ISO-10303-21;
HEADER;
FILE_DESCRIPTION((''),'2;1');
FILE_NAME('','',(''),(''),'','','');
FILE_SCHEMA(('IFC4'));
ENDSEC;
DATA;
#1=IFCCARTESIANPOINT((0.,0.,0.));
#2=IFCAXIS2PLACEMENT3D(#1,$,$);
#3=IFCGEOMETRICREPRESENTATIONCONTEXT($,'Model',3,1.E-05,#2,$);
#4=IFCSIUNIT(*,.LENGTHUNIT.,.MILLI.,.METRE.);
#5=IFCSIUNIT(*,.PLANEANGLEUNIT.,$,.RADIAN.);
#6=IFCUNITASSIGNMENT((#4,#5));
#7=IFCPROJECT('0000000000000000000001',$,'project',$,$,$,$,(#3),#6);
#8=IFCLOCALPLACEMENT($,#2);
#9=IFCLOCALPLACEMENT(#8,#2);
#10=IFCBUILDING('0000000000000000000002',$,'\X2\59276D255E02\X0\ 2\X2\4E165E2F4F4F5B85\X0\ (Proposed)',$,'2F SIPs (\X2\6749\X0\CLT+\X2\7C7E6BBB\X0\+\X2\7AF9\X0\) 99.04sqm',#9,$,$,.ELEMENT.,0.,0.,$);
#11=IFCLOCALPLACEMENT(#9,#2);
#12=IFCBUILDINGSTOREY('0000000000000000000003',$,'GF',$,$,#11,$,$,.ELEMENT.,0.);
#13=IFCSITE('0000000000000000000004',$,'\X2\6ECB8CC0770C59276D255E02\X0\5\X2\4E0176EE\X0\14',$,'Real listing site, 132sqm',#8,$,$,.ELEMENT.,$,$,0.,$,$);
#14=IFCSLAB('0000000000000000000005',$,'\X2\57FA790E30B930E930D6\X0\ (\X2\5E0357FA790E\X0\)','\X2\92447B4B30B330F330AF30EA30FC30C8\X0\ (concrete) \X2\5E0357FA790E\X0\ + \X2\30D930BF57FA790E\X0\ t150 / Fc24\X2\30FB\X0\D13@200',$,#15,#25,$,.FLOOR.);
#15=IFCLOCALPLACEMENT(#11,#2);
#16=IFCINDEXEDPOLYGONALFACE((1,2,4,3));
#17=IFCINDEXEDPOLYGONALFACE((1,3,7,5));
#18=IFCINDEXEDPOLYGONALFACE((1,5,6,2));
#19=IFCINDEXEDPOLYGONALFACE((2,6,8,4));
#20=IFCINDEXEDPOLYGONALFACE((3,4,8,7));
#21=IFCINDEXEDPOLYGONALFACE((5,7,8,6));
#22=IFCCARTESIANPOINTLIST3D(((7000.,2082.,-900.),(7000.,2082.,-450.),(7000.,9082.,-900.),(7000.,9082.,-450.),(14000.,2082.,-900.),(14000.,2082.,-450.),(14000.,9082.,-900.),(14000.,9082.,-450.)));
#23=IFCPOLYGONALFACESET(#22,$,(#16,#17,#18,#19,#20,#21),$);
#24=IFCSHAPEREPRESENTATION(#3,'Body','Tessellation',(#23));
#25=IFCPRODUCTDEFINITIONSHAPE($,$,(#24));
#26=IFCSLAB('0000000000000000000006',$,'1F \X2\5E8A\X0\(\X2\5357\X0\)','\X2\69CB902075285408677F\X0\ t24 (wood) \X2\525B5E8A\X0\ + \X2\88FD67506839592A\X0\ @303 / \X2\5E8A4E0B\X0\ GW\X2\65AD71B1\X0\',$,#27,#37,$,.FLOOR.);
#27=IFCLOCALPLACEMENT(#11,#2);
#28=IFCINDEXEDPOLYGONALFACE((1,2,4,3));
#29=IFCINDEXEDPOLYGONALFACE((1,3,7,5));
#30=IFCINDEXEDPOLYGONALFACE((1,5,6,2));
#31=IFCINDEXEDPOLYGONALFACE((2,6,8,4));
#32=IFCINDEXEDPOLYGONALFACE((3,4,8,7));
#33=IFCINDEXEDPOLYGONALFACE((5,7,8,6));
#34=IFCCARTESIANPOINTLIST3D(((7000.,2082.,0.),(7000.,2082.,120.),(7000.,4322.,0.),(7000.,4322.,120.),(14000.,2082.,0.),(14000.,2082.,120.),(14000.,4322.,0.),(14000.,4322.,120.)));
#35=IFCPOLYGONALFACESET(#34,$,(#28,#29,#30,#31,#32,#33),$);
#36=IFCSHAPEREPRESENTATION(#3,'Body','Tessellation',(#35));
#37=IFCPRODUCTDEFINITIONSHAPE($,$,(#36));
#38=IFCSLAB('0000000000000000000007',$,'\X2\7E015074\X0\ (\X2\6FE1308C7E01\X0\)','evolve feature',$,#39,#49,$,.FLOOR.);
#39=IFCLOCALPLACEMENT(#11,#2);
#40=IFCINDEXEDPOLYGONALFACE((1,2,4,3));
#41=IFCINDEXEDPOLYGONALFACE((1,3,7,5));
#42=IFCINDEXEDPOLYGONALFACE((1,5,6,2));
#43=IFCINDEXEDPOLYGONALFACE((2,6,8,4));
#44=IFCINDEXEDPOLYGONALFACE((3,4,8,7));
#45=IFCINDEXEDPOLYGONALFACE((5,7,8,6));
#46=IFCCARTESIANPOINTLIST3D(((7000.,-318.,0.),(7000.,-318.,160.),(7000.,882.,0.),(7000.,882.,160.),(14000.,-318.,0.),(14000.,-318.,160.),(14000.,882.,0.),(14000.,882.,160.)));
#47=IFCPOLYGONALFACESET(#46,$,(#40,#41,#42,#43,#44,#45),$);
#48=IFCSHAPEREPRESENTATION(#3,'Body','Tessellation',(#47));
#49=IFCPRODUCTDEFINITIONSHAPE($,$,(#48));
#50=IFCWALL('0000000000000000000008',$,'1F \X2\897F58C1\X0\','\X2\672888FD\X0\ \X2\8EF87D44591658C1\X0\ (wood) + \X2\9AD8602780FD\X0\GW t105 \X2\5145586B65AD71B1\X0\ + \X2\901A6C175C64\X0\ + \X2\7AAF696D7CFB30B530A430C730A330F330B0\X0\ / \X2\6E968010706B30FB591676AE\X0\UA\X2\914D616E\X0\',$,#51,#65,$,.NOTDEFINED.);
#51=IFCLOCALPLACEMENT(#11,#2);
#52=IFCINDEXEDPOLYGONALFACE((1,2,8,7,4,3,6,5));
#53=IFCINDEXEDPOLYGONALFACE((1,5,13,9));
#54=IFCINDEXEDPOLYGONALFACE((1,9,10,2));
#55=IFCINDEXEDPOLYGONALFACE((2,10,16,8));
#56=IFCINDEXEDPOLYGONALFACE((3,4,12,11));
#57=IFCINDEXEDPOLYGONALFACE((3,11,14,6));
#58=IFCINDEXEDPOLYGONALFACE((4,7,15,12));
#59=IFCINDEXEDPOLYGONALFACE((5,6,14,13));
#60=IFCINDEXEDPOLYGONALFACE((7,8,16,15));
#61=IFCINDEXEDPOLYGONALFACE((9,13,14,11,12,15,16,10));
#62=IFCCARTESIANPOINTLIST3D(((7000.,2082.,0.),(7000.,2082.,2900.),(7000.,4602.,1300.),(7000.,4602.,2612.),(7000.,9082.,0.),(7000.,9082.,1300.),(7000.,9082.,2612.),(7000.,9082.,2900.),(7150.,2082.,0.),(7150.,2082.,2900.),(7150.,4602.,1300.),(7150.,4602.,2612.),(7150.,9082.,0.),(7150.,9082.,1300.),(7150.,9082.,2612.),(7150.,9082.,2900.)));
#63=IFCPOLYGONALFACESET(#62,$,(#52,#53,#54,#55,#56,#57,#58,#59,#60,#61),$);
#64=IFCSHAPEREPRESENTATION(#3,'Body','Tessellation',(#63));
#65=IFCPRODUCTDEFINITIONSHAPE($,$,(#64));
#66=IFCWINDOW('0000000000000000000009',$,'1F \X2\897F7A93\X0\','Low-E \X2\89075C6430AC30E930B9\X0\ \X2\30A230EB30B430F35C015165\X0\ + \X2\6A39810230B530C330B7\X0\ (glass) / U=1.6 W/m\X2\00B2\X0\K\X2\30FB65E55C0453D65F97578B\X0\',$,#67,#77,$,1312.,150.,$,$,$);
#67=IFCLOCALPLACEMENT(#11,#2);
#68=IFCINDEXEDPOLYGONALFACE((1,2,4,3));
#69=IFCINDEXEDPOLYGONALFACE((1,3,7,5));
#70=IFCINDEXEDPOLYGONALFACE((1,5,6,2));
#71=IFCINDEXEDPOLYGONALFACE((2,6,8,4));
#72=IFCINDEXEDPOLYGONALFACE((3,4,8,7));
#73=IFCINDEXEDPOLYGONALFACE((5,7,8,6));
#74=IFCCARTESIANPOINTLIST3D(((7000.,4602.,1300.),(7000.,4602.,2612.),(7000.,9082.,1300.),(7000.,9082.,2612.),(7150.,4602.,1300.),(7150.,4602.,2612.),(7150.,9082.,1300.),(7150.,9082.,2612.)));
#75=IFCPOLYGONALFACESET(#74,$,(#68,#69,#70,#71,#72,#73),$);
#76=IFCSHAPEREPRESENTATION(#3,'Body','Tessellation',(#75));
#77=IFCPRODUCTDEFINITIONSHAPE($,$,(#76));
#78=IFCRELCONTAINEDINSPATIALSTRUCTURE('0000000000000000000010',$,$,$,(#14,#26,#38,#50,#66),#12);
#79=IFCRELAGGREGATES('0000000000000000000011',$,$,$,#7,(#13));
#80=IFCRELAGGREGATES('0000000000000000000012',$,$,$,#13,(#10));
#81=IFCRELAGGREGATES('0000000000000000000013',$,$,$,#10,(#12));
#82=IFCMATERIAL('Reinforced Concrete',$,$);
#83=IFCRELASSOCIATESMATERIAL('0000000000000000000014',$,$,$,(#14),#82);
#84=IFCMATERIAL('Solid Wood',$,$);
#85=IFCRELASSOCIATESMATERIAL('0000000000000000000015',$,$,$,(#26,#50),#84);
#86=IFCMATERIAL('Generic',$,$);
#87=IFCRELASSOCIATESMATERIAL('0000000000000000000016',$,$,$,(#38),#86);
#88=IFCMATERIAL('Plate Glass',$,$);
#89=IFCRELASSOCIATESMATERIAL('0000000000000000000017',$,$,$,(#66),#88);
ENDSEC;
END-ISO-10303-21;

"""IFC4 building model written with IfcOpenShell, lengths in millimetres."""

from ifc_helpers import new_model, si_unit, frame, frame_2d, origin, place, context, project, spatial, rectangle, extrude, material, element, fill, save


model = new_model("IFC4")

# Units and contexts
model_context = context("Model", 3, precision=1e-05, world=origin())
ifc_project = project(units=[si_unit("LENGTHUNIT", "METRE", prefix="MILLI"), si_unit("PLANEANGLEUNIT", "RADIAN")], contexts=[model_context])

# Site, building, storey
site_placement = place(None, origin())
site = spatial("IfcSite", under=ifc_project, at=site_placement, Name="滋賀県大津市5丁目14", ObjectType="Real listing site, 132sqm", CompositionType="ELEMENT", RefElevation=0.0)
building_placement = place(site_placement, origin())
building = spatial("IfcBuilding", under=site, at=building_placement, Name="大津市 2世帯住宅 (Proposed)", ObjectType="2F SIPs (杉CLT+籾殻+竹) 99.04sqm", CompositionType="ELEMENT", ElevationOfRefHeight=0.0, ElevationOfTerrain=0.0)
storey_placement = place(building_placement, origin())
storey = spatial("IfcBuildingStorey", under=building, at=storey_placement, Name="GF", CompositionType="ELEMENT", Elevation=0.0)

# Slabs
ifc_material_1 = material(Name="Reinforced Concrete")
slab_1_placement = place(storey_placement, frame((3500.0, 1041.0, -450.0)))
element("IfcSlab", 1, at=slab_1_placement, inside=storey, material=ifc_material_1, Name="基礎スラブ (布基礎)", Description="鉄筋コンクリート (concrete) 布基礎 + ベタ基礎 t150 / Fc24・D13@200", PredefinedType="FLOOR", context=model_context, shape_type="SweptSolid", body=[
    extrude(rectangle(XDim=7000.0, YDim=7000.0, at=frame_2d((3500.0, 3500.0))), frame((3500.0, 1041.0, -450.0)), (0.0, 0.0, 1.0), 450.0),
])
ifc_material_2 = material(Name="Solid Wood")
slab_2_placement = place(storey_placement, frame((3500.0, 1041.0, 0.0)))
element("IfcSlab", 2, at=slab_2_placement, inside=storey, material=ifc_material_2, Name="1F 床(南)", Description="構造用合板 t24 (wood) 剛床 + 製材根太 @303 / 床下 GW断熱", PredefinedType="FLOOR", context=model_context, shape_type="SweptSolid", body=[
    extrude(rectangle(XDim=7000.0, YDim=2240.0, at=frame_2d((3500.0, 1120.0))), frame((3500.0, 1041.0, 0.0)), (0.0, 0.0, 1.0), 120.0),
])
ifc_material_3 = material(Name="Generic")
slab_3_placement = place(storey_placement, frame((3500.0, -159.0, 0.0)))
element("IfcSlab", 3, at=slab_3_placement, inside=storey, material=ifc_material_3, Name="縁側 (濡れ縁)", Description="evolve feature", PredefinedType="FLOOR", context=model_context, shape_type="SweptSolid", body=[
    extrude(rectangle(XDim=7000.0, YDim=1200.0, at=frame_2d((3500.0, 600.0))), frame((3500.0, -159.0, 0.0)), (0.0, 0.0, 1.0), 160.0),
])

# Shared definitions
ifc_material_4 = material(Name="Plate Glass")

# Wall, opening, window
wall_1_placement = place(storey_placement, frame((3500.0, 1041.0, 0.0)))
wall_1 = element("IfcWall", 4, at=wall_1_placement, inside=storey, material=ifc_material_2, Name="1F 西壁", Description="木製 軸組外壁 (wood) + 高性能GW t105 充填断熱 + 通気層 + 窯業系サイディング / 準耐火・外皮UA配慮", PredefinedType="NOTDEFINED", context=model_context, shape_type="SweptSolid", body=[
    extrude(rectangle(XDim=150.0, YDim=7000.0, at=frame_2d((75.0, 3500.0))), frame((3500.0, 1041.0, 0.0)), (0.0, 0.0, 1.0), 2900.0),
])
opening_1_placement = place(storey_placement, frame((3500.0, 2301.0, 650.0)))
opening_1 = element("IfcOpeningElement", 5, at=opening_1_placement, cuts=wall_1, PredefinedType="NOTDEFINED", context=model_context, shape_type="SweptSolid", body=[
    extrude(rectangle(XDim=150.0, YDim=4480.0, at=frame_2d((75.0, 2240.0))), frame((3500.0, 2301.0, 650.0)), (0.0, 0.0, 1.0), 1312.0),
])
window_1_placement = place(storey_placement, frame((3500.0, 2301.0, 650.0)))
window_1 = element("IfcWindow", 6, at=window_1_placement, inside=storey, material=ifc_material_4, Name="1F 西窓", Description="Low-E 複層ガラス アルゴン封入 + 樹脂サッシ (glass) / U=1.6 W/m²K・日射取得型", OverallHeight=1312.0, OverallWidth=150.0, context=model_context, shape_type="SweptSolid", body=[
    extrude(rectangle(XDim=150.0, YDim=4480.0, at=frame_2d((75.0, 2240.0))), frame((3500.0, 2301.0, 650.0)), (0.0, 0.0, 1.0), 1312.0),
])
fill(opening_1, window_1)

save(model, "model.ifc")
